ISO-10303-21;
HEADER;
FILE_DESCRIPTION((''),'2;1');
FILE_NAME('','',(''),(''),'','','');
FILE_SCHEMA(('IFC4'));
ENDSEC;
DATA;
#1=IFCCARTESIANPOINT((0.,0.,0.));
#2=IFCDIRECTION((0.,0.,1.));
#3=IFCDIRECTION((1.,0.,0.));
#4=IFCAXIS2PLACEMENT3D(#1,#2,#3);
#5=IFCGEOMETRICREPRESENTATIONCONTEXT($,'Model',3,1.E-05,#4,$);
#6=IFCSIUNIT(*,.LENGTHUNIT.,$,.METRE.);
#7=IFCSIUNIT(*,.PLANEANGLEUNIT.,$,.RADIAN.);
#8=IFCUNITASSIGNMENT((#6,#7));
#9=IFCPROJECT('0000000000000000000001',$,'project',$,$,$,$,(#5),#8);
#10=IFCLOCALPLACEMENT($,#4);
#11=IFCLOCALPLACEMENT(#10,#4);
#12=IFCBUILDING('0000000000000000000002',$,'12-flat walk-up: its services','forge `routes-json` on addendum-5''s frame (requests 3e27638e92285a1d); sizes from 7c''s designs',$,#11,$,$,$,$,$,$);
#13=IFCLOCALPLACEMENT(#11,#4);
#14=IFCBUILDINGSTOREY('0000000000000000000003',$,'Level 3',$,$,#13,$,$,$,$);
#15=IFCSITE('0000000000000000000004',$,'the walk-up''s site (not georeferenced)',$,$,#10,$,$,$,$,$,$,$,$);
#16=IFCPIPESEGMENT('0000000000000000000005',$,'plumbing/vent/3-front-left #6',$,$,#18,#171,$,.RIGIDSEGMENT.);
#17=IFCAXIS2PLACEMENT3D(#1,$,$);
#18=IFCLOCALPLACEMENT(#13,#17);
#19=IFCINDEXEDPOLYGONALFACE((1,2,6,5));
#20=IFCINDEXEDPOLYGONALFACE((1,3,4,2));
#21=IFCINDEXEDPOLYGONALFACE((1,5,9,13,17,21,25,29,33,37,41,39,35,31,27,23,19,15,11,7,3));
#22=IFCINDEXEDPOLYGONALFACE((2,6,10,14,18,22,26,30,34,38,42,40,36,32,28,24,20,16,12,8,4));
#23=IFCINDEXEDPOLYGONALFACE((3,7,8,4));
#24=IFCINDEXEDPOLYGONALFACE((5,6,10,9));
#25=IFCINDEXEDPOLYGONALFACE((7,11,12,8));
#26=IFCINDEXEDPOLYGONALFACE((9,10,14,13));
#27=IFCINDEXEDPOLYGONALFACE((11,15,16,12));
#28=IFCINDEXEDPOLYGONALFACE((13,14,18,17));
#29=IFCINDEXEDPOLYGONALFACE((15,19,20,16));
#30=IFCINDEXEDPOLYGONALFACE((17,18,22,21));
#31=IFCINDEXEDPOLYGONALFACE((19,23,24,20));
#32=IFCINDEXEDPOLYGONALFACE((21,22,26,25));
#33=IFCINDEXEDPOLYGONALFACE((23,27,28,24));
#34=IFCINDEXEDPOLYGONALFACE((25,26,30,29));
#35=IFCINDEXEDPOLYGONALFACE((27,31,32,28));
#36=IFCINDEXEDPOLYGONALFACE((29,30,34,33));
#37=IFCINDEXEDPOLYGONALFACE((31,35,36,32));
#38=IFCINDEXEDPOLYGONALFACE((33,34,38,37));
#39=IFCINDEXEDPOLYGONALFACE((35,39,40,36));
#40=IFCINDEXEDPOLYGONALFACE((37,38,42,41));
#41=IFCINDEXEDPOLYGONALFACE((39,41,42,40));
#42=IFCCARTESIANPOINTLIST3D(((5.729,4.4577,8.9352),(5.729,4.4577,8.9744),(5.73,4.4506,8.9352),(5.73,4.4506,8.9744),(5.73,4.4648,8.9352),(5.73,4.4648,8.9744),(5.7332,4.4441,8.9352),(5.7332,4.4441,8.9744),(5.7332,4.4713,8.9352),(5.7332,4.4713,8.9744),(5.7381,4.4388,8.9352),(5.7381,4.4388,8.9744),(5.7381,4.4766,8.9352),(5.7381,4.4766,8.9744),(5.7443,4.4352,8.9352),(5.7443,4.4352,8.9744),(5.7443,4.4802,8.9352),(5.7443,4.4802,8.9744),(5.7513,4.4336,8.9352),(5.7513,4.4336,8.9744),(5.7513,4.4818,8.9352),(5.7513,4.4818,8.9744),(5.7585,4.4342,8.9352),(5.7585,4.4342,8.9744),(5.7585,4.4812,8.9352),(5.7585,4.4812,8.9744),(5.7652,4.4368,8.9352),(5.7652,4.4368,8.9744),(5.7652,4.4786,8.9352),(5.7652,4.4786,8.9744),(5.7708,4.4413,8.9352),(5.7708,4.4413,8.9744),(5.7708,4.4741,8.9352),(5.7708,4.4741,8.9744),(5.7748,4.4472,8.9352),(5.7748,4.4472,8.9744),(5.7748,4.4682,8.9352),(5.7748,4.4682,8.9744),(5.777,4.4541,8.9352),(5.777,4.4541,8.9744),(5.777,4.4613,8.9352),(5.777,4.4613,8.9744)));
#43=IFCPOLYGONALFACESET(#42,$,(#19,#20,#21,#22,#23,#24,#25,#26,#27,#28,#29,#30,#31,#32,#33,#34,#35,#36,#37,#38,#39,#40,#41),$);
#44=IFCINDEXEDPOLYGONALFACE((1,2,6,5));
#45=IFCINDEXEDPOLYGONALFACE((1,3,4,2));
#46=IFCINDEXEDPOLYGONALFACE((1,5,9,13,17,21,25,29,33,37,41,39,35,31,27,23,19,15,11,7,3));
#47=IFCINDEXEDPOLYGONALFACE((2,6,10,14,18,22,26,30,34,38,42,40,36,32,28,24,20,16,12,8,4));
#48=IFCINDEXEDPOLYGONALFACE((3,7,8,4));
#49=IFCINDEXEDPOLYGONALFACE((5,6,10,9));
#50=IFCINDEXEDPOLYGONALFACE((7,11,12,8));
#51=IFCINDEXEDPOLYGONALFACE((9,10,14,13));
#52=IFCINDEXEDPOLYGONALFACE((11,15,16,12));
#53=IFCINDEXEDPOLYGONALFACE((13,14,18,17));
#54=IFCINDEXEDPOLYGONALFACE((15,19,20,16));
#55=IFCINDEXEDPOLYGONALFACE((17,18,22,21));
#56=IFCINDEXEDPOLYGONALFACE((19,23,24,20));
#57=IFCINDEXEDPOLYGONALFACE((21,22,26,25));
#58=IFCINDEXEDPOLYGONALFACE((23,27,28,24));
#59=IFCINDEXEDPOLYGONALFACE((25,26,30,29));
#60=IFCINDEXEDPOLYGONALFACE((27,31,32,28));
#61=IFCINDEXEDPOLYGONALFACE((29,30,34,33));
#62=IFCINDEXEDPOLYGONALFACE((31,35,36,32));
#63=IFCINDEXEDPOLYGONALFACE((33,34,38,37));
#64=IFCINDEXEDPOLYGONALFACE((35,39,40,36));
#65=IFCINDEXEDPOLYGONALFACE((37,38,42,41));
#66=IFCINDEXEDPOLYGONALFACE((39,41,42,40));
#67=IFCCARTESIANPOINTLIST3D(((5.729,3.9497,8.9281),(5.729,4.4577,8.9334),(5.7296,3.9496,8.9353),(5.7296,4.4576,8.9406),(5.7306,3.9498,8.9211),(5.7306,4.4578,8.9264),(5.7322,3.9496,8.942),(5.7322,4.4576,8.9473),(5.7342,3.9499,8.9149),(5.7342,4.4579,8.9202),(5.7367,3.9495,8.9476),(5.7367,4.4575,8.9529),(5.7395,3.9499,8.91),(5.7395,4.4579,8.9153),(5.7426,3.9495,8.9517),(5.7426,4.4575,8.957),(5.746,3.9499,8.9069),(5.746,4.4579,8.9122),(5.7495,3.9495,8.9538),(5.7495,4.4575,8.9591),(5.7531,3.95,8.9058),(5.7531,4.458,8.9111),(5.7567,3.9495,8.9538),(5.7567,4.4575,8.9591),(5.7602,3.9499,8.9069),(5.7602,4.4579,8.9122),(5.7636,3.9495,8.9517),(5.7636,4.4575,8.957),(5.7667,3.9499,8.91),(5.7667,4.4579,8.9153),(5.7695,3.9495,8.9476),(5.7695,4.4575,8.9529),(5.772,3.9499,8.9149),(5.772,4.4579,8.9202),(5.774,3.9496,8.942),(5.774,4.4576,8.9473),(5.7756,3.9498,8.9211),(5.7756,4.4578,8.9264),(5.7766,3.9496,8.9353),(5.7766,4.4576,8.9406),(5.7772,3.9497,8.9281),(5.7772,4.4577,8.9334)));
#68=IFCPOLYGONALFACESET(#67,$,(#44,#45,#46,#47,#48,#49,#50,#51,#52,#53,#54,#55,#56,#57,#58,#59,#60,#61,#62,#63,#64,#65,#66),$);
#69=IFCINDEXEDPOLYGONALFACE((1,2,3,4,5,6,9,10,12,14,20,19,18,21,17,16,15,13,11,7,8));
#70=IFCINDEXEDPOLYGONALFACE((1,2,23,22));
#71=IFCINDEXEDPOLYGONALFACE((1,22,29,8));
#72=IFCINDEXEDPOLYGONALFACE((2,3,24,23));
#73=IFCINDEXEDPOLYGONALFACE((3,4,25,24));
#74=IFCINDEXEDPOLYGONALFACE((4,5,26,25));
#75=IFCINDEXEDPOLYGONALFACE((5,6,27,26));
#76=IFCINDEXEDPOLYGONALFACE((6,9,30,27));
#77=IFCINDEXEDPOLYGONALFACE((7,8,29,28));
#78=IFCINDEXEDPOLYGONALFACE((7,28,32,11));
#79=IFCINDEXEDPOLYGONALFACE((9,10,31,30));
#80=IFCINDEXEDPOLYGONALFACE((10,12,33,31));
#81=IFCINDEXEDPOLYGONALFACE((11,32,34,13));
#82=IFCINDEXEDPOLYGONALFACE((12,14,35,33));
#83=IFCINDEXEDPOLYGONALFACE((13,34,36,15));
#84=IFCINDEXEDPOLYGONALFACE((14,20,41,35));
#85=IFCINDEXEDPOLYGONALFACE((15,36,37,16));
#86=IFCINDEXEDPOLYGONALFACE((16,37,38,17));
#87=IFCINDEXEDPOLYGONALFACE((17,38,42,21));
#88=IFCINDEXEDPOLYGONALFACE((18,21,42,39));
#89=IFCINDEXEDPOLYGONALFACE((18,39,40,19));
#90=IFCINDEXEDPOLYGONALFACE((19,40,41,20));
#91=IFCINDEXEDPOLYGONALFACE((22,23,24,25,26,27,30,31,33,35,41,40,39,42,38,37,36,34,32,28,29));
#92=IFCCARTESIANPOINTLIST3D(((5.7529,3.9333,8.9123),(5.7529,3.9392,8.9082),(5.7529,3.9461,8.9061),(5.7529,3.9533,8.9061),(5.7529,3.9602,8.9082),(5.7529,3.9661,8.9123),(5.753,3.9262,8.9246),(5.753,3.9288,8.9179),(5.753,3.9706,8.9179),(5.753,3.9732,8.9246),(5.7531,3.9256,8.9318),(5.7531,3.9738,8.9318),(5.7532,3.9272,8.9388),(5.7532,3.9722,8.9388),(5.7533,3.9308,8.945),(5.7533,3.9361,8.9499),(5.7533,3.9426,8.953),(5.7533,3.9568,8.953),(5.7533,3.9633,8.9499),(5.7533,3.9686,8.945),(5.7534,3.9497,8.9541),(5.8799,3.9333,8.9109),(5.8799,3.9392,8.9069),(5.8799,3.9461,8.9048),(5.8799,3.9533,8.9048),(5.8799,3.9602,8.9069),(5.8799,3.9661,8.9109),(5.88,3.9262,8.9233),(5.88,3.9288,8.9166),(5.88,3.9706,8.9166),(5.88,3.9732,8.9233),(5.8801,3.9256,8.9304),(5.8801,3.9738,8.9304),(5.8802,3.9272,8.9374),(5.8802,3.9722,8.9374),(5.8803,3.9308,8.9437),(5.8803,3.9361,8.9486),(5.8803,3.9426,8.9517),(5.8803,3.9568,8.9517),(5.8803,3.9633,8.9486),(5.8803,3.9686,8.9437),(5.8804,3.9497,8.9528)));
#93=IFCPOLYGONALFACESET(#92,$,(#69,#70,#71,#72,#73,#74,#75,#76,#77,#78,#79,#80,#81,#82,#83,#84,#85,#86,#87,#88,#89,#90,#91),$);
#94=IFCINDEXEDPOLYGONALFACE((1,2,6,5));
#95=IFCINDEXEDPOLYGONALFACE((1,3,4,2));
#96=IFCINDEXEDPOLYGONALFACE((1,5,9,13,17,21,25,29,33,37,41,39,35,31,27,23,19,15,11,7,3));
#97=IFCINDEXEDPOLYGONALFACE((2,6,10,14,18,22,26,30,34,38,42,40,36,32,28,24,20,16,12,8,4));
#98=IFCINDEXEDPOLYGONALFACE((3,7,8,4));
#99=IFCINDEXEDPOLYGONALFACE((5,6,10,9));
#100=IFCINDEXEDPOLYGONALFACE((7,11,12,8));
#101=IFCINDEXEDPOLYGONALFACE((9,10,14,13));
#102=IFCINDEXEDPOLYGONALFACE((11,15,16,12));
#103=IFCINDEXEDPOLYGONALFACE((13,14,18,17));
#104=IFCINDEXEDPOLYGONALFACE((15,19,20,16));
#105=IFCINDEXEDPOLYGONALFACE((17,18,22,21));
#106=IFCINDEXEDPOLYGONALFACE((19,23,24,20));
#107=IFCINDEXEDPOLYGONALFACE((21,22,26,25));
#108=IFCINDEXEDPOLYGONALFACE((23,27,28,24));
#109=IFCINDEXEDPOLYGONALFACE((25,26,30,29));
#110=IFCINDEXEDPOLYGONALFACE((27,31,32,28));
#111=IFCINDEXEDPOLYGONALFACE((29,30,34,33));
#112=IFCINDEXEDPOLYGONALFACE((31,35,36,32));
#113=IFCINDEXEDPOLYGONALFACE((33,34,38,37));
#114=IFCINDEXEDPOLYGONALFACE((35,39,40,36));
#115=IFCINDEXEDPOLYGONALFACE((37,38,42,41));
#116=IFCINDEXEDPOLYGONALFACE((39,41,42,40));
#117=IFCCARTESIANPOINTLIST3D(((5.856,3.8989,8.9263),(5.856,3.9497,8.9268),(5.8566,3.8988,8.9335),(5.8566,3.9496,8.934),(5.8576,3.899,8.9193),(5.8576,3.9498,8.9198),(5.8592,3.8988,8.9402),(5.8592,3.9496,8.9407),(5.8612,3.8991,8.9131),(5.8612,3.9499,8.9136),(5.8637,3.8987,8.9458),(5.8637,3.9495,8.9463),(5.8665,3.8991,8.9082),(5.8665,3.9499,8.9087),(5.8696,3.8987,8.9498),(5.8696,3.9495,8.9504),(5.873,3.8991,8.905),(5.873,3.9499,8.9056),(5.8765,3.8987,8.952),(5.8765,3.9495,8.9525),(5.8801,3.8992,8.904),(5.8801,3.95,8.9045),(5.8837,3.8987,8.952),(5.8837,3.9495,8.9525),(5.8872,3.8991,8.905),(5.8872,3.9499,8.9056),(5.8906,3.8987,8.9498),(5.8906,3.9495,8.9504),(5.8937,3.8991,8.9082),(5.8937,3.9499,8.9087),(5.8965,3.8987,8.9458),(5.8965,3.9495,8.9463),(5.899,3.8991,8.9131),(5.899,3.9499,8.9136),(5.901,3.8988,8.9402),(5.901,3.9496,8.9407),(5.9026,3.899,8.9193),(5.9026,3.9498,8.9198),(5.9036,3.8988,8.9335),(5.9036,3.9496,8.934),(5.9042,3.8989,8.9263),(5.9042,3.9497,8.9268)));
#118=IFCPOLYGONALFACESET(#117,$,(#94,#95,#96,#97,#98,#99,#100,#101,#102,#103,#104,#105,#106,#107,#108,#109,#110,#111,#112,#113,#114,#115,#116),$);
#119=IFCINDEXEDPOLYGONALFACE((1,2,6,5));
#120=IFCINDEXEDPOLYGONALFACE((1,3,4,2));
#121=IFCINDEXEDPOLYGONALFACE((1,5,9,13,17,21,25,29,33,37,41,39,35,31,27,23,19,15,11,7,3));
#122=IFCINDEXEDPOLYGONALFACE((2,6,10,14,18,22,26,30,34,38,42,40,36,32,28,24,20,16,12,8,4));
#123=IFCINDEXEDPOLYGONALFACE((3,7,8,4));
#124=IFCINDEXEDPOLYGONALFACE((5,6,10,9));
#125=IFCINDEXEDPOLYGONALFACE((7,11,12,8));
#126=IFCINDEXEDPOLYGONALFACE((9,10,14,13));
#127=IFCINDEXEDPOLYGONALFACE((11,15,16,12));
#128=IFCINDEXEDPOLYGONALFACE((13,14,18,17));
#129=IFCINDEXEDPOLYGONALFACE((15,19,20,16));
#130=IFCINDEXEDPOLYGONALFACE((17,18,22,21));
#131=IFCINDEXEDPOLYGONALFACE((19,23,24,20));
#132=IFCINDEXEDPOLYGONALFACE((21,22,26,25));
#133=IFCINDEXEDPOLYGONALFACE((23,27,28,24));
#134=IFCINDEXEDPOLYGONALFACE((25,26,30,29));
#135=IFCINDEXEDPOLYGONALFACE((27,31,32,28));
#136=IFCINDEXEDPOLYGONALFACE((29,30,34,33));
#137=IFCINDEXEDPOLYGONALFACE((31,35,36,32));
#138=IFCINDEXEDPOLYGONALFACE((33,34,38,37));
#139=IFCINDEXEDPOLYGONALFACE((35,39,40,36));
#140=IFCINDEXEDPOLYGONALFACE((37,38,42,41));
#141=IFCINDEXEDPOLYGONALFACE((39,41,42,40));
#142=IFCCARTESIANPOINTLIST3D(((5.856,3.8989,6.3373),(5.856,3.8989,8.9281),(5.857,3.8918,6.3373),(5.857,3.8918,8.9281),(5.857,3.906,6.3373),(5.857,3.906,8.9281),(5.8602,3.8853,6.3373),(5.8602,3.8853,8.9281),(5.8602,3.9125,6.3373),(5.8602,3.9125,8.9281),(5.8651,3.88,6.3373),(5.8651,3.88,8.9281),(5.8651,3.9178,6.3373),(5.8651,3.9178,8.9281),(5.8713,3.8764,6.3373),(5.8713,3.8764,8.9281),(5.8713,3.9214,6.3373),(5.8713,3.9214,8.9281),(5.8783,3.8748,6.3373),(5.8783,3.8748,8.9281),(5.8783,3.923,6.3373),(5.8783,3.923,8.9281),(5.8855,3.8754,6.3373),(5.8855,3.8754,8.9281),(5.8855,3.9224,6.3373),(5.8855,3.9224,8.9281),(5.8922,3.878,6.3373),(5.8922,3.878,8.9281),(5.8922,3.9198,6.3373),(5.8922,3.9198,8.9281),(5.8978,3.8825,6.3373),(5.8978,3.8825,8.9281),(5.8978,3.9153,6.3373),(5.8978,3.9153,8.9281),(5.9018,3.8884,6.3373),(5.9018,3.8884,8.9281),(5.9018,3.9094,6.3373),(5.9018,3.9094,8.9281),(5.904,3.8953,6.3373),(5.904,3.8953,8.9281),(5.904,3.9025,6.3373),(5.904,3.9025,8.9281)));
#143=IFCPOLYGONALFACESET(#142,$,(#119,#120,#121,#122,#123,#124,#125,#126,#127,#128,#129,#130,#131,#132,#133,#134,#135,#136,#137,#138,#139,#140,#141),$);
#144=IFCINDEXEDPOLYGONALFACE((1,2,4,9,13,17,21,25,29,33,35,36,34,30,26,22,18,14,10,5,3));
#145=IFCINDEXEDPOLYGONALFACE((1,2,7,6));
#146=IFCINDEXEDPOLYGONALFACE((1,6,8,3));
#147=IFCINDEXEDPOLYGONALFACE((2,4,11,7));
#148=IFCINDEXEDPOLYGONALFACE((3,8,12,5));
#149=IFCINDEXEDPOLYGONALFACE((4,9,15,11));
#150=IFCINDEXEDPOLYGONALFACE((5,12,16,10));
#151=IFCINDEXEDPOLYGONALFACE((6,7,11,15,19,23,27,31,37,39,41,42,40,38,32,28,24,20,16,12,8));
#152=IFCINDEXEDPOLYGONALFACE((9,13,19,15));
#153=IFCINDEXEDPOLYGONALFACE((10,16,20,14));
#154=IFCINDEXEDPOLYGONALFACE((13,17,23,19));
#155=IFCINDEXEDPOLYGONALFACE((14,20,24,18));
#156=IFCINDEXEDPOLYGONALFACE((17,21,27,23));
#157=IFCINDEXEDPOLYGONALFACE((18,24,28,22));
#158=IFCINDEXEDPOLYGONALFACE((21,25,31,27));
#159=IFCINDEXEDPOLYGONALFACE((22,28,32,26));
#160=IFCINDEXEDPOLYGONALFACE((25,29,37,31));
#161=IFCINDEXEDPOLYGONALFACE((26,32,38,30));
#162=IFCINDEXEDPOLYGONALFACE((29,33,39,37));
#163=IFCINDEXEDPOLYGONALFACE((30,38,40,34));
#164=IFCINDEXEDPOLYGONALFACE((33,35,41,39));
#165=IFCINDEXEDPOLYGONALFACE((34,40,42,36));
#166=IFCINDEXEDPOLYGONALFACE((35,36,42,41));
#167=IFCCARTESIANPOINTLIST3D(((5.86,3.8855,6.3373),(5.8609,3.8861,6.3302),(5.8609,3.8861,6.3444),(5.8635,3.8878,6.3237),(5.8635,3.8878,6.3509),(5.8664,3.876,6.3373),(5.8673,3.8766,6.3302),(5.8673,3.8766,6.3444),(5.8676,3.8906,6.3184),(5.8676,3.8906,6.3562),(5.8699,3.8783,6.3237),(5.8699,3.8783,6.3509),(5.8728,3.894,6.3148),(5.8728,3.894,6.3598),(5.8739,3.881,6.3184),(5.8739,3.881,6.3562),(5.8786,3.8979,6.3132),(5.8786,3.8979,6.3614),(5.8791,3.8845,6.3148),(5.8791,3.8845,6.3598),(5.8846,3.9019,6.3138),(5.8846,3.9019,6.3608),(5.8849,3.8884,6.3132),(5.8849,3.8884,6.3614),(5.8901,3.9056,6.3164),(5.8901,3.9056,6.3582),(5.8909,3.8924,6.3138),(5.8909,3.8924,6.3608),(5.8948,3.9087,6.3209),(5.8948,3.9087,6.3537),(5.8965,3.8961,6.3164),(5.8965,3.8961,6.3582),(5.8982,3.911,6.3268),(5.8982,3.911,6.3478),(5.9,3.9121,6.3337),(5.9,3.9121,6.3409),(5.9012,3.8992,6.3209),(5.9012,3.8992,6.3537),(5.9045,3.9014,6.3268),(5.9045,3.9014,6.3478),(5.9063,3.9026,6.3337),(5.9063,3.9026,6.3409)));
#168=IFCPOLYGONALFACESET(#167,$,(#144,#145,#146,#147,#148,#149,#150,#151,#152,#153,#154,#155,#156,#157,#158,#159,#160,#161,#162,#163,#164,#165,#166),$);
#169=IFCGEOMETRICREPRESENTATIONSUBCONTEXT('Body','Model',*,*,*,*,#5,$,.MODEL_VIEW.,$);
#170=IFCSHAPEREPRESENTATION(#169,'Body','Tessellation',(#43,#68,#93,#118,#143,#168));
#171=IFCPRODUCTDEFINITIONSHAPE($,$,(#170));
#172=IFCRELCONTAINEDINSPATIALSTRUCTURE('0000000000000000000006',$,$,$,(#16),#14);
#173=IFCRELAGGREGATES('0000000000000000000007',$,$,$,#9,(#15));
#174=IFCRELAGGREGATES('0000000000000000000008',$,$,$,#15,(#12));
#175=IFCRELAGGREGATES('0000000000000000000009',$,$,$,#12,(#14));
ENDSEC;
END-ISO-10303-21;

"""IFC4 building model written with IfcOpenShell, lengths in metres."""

from ifc_helpers import new_model, entity, si_unit, frame, origin_with_axes, place, context, subcontext, project, spatial, element, save


model = new_model("IFC4")

# Units and contexts
model_context = context("Model", 3, precision=1e-05, world=origin_with_axes())
body_context = subcontext(model_context, "Body", "Model", "MODEL_VIEW")
ifc_project = project(units=[si_unit("LENGTHUNIT", "METRE"), si_unit("PLANEANGLEUNIT", "RADIAN")], contexts=[model_context])

# Site, building, storey
site_placement = place(None, origin_with_axes())
site = spatial("IfcSite", under=ifc_project, at=site_placement, Name="the walk-up's site (not georeferenced)")
building_placement = place(site_placement, origin_with_axes())
building = spatial("IfcBuilding", under=site, at=building_placement, Name="12-flat walk-up: its services", Description="forge `routes-json` on addendum-5's frame (requests 3e27638e92285a1d); sizes from 7c's designs")
storey_placement = place(building_placement, origin_with_axes())
storey = spatial("IfcBuildingStorey", under=building, at=storey_placement, Name="Level 3")

# Pipe segment
pipe_segment_1_placement = place(storey_placement, frame((5.7531, 4.4577, 8.9744), z_axis=(0.0, 0.0, 1.0), x_axis=(1.0, 0.0, 0.0)))
element("IfcPipeSegment", 1, at=pipe_segment_1_placement, inside=storey, Name="plumbing/vent/3-front-left #6", PredefinedType="RIGIDSEGMENT", context=body_context, shape_type="AdvancedSweptSolid", body=[
    entity("IfcSweptDiskSolid", entity("IfcPolyline", [entity("IfcCartesianPoint", [0.0, 0.0, 0.0]), entity("IfcCartesianPoint", [0.0, 0.0, -0.0392])]), 0.0241),
    entity("IfcSweptDiskSolid", entity("IfcPolyline", [entity("IfcCartesianPoint", [0.0, 0.0, -0.0392]), entity("IfcCartesianPoint", [0.0, -0.508, -0.0445])]), 0.0241),
    entity("IfcSweptDiskSolid", entity("IfcPolyline", [entity("IfcCartesianPoint", [0.0, -0.508, -0.0445]), entity("IfcCartesianPoint", [0.127, -0.508, -0.0458])]), 0.0241),
    entity("IfcSweptDiskSolid", entity("IfcPolyline", [entity("IfcCartesianPoint", [0.127, -0.508, -0.0458]), entity("IfcCartesianPoint", [0.127, -0.5588, -0.0463])]), 0.0241),
    entity("IfcSweptDiskSolid", entity("IfcPolyline", [entity("IfcCartesianPoint", [0.127, -0.5588, -0.0463]), entity("IfcCartesianPoint", [0.127, -0.5588, -2.6371])]), 0.0241),
    entity("IfcSweptDiskSolid", entity("IfcPolyline", [entity("IfcCartesianPoint", [0.127, -0.5588, -2.6371]), entity("IfcCartesianPoint", [0.1334, -0.5683, -2.6371])]), 0.0241),
])

save(model, "model.ifc")
